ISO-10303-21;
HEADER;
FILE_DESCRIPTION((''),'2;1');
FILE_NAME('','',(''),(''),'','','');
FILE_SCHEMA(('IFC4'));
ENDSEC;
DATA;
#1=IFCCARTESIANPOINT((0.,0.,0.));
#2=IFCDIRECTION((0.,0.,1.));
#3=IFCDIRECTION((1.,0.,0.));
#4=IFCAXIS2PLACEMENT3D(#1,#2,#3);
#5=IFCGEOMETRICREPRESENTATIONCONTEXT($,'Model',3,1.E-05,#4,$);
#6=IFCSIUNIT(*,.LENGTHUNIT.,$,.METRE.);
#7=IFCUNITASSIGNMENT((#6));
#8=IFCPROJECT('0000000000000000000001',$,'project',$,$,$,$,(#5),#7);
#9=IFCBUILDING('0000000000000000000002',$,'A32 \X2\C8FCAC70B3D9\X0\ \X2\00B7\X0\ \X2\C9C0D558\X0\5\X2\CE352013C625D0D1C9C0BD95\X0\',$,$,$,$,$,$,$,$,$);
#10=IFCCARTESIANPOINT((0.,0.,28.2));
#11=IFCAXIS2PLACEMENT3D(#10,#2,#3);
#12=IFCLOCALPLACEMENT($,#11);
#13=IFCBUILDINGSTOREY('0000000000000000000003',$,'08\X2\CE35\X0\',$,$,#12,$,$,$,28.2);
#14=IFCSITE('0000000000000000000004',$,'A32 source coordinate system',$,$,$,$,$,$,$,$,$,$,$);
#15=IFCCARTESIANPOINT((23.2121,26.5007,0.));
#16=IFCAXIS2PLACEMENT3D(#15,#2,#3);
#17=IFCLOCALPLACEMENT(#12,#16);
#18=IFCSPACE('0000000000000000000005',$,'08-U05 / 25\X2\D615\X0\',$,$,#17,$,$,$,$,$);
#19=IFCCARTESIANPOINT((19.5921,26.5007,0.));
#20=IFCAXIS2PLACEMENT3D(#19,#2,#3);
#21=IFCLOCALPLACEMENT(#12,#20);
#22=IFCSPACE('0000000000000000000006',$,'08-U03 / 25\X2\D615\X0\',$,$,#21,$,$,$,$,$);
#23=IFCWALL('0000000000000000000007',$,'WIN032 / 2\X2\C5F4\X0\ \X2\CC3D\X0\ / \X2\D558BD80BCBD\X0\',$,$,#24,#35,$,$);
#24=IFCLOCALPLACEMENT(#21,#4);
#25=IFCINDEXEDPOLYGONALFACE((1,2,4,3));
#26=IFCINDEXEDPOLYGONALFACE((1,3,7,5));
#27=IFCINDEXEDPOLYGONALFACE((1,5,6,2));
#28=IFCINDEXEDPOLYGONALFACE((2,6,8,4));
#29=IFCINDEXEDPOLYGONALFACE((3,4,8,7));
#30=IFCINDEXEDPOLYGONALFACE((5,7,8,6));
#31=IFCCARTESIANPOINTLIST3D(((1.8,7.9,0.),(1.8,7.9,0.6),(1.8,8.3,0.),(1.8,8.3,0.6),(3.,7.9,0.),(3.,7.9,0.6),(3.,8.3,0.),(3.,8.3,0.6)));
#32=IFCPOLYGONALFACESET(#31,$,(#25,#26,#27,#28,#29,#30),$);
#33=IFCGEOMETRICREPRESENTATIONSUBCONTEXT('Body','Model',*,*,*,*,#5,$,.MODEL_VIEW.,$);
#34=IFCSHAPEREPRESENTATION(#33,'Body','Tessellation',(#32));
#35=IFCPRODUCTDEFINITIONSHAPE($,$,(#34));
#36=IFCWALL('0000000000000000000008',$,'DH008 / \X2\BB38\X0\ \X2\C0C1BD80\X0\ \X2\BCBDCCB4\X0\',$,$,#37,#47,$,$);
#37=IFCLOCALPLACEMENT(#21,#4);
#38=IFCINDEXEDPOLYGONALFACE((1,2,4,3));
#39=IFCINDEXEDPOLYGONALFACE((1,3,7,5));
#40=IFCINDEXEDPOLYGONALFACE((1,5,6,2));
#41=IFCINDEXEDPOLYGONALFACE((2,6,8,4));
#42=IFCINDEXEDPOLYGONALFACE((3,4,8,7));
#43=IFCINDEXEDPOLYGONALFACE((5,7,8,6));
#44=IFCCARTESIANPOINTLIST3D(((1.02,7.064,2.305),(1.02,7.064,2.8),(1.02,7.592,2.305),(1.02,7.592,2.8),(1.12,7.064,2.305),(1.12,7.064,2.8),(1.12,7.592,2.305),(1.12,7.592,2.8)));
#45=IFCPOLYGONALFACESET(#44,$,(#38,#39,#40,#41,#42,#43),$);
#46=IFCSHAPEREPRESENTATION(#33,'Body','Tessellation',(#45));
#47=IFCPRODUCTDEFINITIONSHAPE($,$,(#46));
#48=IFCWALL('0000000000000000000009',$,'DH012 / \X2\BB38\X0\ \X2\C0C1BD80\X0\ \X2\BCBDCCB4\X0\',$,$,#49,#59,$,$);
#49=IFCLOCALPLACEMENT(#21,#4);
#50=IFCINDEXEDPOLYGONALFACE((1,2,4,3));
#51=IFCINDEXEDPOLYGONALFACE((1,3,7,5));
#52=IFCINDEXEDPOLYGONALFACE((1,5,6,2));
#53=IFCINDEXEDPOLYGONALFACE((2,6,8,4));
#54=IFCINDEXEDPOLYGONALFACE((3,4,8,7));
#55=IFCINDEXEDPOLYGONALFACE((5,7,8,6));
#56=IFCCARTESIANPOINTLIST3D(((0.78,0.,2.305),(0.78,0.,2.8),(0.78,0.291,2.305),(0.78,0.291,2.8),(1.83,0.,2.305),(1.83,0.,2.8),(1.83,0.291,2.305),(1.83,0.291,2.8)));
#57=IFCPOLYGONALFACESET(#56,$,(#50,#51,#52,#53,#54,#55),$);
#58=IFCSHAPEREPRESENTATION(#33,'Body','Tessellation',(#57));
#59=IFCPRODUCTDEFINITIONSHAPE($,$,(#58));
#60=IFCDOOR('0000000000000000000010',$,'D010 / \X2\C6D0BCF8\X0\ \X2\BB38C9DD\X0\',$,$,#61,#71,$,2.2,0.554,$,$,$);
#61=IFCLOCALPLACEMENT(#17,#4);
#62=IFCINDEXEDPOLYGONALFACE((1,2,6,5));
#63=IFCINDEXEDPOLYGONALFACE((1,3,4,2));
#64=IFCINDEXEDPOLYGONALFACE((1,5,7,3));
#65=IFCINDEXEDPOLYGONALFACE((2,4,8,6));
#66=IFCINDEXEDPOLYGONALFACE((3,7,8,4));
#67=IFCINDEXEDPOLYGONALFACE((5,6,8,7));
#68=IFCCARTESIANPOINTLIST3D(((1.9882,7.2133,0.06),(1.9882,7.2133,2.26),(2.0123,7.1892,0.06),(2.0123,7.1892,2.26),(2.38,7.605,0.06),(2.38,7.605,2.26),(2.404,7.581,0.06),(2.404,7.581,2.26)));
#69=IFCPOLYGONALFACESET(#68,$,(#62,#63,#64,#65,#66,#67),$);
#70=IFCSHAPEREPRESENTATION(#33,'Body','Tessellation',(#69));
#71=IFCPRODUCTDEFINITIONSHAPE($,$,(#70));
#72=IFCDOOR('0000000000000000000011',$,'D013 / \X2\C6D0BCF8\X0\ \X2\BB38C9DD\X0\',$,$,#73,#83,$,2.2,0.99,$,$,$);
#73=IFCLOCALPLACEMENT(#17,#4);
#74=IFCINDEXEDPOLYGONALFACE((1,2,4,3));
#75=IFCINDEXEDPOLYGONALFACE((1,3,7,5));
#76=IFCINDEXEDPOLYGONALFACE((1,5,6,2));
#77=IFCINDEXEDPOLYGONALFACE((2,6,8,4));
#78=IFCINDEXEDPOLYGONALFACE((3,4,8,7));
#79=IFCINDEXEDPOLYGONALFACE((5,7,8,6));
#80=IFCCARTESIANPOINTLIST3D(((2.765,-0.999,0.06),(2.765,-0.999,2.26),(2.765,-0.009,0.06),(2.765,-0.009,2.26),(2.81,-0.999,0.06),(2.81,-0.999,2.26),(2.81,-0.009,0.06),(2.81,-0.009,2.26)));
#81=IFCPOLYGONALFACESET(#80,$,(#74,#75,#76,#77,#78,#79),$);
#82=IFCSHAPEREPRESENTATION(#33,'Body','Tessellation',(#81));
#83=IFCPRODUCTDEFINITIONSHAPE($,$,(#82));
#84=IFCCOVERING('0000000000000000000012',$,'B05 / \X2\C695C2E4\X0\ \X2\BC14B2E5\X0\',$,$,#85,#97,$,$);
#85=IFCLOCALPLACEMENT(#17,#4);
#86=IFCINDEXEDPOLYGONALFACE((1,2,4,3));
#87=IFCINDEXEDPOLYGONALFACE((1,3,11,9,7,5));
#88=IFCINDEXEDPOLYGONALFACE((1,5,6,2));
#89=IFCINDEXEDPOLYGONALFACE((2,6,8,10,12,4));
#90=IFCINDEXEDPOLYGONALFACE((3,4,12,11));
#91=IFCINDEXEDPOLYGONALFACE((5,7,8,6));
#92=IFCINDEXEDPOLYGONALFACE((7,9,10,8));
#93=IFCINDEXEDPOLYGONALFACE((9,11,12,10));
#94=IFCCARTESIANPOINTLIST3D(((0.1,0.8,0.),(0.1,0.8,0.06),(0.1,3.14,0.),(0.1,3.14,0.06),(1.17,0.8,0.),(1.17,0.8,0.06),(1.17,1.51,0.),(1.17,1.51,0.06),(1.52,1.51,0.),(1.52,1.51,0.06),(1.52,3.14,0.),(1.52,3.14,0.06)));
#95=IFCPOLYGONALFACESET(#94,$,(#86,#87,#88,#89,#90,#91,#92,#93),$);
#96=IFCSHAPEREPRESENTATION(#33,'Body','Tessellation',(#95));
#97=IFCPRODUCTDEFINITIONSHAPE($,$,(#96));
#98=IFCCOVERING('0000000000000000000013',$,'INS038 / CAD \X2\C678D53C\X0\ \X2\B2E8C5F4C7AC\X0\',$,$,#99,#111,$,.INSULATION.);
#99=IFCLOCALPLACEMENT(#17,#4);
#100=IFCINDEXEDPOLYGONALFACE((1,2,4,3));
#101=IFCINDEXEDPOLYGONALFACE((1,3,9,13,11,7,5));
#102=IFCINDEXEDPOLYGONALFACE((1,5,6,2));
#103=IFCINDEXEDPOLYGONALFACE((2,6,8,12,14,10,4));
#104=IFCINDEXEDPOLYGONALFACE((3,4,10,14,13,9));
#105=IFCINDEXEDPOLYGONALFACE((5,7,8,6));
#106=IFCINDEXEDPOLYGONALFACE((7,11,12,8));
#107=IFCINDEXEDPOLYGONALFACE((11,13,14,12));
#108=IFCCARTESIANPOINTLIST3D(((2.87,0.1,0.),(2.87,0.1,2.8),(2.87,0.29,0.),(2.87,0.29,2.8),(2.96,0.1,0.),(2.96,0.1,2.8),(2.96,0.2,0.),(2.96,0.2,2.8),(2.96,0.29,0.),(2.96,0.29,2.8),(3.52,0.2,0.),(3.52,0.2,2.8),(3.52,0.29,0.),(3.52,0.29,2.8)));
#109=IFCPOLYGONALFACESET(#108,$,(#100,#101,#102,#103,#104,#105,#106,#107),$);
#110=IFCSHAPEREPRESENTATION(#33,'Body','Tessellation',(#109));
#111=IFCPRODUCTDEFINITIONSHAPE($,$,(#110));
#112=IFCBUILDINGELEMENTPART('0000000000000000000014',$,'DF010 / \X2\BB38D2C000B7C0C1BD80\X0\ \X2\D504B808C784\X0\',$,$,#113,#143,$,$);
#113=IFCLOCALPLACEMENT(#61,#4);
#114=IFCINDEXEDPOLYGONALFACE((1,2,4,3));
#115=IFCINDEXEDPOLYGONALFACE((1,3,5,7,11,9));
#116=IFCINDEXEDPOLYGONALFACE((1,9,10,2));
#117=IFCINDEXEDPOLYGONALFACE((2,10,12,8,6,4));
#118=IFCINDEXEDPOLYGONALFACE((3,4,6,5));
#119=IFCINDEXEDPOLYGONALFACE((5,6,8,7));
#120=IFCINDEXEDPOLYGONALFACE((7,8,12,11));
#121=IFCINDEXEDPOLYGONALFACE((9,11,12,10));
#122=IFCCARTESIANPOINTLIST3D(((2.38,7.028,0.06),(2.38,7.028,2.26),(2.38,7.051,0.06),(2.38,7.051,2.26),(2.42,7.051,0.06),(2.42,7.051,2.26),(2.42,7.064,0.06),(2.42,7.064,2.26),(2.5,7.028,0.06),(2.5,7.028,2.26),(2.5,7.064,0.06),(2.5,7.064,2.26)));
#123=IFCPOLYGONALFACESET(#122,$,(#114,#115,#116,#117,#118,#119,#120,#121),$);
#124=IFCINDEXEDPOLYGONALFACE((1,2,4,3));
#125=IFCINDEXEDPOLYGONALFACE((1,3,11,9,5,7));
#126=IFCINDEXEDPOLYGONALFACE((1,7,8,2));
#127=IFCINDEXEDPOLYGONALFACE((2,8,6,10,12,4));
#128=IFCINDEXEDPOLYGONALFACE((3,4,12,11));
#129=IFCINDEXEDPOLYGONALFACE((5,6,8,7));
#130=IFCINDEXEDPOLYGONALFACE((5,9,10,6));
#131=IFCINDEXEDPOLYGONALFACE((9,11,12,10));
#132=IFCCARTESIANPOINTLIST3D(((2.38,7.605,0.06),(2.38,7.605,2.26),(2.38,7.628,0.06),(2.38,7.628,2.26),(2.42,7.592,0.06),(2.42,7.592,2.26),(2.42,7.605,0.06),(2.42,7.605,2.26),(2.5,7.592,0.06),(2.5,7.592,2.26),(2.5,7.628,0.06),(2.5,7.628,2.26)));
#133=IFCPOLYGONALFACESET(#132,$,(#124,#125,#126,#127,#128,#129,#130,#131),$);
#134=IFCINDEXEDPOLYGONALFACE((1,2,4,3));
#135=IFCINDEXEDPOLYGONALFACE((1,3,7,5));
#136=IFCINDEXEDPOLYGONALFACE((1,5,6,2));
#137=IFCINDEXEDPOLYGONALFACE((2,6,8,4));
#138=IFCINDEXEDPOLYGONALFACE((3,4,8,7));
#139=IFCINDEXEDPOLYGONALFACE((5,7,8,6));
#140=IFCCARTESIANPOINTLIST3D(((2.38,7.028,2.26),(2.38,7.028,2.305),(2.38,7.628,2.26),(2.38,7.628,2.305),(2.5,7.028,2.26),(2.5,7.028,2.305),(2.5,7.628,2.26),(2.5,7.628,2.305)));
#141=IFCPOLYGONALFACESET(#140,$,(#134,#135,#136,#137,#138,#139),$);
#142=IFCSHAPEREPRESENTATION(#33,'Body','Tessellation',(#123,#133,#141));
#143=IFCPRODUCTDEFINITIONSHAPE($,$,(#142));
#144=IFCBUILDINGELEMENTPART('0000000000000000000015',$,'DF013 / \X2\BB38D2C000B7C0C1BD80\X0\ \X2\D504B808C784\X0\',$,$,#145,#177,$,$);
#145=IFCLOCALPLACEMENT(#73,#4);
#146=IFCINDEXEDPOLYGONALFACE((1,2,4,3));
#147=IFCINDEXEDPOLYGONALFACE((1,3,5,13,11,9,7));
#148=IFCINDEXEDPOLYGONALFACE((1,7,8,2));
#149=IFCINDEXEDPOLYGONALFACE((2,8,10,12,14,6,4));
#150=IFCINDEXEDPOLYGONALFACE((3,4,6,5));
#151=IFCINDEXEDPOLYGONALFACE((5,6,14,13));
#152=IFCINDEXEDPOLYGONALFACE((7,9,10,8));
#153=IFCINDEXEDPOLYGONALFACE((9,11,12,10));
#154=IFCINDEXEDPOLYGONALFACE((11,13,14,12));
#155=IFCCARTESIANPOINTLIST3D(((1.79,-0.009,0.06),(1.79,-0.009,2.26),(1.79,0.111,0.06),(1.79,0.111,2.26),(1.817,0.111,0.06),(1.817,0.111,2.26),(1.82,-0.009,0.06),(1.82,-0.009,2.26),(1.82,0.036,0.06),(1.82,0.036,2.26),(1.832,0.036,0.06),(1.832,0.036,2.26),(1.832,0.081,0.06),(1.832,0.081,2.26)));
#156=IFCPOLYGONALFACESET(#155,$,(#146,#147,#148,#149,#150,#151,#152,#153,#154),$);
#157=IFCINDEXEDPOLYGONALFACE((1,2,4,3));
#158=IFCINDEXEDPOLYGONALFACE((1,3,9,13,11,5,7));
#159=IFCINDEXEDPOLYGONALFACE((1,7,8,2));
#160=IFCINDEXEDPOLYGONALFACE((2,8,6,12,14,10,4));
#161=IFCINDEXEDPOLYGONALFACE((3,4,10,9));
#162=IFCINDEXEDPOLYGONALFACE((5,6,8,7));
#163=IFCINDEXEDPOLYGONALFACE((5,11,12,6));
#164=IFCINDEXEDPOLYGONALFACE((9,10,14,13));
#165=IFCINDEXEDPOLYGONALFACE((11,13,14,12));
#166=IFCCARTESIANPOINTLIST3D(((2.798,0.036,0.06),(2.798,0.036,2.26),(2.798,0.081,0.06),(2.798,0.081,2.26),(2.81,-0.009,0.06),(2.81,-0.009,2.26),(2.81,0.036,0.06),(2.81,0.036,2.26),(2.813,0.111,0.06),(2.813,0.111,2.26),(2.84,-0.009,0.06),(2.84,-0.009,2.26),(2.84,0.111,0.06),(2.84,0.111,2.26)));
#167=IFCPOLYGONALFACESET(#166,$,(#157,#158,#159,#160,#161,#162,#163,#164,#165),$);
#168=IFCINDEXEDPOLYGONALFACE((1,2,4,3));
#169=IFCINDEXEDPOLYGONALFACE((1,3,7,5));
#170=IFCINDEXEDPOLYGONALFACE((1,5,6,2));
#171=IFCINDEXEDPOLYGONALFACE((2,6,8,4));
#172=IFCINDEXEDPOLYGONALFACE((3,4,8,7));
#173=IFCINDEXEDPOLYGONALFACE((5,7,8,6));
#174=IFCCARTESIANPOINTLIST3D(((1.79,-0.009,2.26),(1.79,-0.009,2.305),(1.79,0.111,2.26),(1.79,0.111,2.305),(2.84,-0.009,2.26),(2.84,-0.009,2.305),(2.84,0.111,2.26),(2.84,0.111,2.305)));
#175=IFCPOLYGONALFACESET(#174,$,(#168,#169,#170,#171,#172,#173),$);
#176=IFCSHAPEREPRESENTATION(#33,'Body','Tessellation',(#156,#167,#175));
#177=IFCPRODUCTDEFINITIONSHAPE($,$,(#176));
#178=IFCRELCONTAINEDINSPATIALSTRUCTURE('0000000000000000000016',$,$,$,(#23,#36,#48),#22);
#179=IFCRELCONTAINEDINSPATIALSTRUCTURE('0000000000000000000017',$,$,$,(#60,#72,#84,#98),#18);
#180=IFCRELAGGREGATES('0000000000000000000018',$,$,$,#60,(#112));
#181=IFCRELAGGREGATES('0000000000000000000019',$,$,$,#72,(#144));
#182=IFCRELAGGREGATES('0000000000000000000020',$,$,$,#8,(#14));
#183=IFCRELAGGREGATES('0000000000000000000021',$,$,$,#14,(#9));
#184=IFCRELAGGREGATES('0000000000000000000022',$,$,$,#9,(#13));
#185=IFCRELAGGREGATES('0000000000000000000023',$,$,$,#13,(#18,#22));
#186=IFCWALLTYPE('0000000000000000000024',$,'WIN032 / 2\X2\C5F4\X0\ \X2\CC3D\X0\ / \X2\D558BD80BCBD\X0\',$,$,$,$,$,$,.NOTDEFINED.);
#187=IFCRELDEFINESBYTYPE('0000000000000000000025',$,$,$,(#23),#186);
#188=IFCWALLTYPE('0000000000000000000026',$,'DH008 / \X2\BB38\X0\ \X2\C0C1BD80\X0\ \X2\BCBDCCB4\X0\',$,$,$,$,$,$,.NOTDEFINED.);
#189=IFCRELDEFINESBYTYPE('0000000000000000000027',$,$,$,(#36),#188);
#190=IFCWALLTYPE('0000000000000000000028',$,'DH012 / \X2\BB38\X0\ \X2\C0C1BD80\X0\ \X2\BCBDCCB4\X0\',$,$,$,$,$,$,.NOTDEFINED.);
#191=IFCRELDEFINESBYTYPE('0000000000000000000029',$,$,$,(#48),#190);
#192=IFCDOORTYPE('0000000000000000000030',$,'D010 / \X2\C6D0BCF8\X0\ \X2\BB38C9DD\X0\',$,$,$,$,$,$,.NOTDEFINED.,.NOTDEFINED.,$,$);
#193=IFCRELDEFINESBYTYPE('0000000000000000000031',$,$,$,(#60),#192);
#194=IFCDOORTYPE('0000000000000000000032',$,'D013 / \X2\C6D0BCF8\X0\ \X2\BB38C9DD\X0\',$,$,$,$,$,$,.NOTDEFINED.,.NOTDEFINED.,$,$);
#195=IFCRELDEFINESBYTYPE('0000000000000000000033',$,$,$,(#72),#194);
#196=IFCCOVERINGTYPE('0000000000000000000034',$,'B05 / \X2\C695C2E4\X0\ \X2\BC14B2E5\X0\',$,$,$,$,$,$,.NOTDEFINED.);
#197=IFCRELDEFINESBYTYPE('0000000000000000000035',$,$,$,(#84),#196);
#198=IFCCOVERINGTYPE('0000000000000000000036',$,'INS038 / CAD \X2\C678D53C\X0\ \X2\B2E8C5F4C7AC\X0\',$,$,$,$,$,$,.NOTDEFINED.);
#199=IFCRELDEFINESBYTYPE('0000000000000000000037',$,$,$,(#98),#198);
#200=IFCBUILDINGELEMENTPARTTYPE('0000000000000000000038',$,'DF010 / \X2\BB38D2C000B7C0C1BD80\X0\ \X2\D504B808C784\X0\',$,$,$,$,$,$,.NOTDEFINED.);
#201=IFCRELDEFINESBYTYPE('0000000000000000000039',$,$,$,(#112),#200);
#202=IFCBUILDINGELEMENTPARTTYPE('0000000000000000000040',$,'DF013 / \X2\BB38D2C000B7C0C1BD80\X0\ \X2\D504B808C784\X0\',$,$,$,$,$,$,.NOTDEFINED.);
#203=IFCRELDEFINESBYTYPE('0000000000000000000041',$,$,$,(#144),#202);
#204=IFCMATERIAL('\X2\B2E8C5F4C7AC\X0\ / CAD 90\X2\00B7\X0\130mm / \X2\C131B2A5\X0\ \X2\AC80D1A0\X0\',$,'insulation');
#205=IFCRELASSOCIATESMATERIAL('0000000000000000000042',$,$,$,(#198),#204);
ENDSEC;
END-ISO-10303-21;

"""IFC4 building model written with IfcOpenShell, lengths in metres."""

from ifc_helpers import new_model, si_unit, frame, origin, origin_with_axes, place, context, subcontext, project, spatial, polyline, outline, extrude, source, transform, mapped, material, type_object, type_shapes, element, aggregate, save


model = new_model("IFC4")

# Units and contexts
model_context = context("Model", 3, precision=1e-05, world=origin_with_axes())
body_context = subcontext(model_context, "Body", "Model", "MODEL_VIEW")
ifc_project = project(units=[si_unit("LENGTHUNIT", "METRE")], contexts=[model_context])

# Site, building, storey, space
storey_placement = place(None, frame((0.0, 0.0, 28.2), z_axis=(0.0, 0.0, 1.0), x_axis=(1.0, 0.0, 0.0)))
space_1_placement = place(storey_placement, frame((23.2121, 26.5007, 0.0), z_axis=(0.0, 0.0, 1.0), x_axis=(1.0, 0.0, 0.0)))
site = spatial("IfcSite", under=ifc_project, Name="A32 source coordinate system")
building = spatial("IfcBuilding", under=site, Name="A32 주거동 · 지하5층–옥탑지붕")
storey = spatial("IfcBuildingStorey", under=building, at=storey_placement, Name="08층", Elevation=28.2)
space_1 = spatial("IfcSpace", under=storey, at=space_1_placement, Name="08-U05 / 25형")

# Shared definitions
space_2_placement = place(storey_placement, frame((19.5921, 26.5007, 0.0), z_axis=(0.0, 0.0, 1.0), x_axis=(1.0, 0.0, 0.0)))
space_2 = spatial("IfcSpace", under=storey, at=space_2_placement, Name="08-U03 / 25형")

# Walls
wall_type_1 = type_object("IfcWallType", Name="WIN032 / 2열 창 / 하부벽", PredefinedType="NOTDEFINED")
shared_shape_1 = source(origin(), body_context, "Body", "SweptSolid", [
    extrude(outline(polyline([(3.0, 7.9), (1.8, 7.9), (1.8, 8.3), (3.0, 8.3), (3.0, 7.9)])), origin(), (0.0, 0.0, 1.0), 0.6),
])
type_shapes(wall_type_1, [shared_shape_1])
wall_1_placement = place(space_2_placement, origin_with_axes())
element("IfcWall", 1, at=wall_1_placement, inside=space_2, type_object=wall_type_1, Name="WIN032 / 2열 창 / 하부벽", context=body_context, shape_type="MappedRepresentation", body=[
    mapped(shared_shape_1, transform((0.0, 0.0, 0.0), scale=1.0)),
])
wall_type_2 = type_object("IfcWallType", Name="DH008 / 문 상부 벽체", PredefinedType="NOTDEFINED")
shared_shape_2 = source(origin(), body_context, "Body", "SweptSolid", [
    extrude(outline(polyline([(1.12, 7.064), (1.02, 7.064), (1.02, 7.592), (1.12, 7.592), (1.12, 7.064)])), frame((0.0, 0.0, 2.305)), (0.0, 0.0, 1.0), 0.495),
])
type_shapes(wall_type_2, [shared_shape_2])
wall_2_placement = place(space_2_placement, origin_with_axes())
element("IfcWall", 2, at=wall_2_placement, inside=space_2, type_object=wall_type_2, Name="DH008 / 문 상부 벽체", context=body_context, shape_type="MappedRepresentation", body=[
    mapped(shared_shape_2, transform((0.0, 0.0, 0.0), scale=1.0)),
])
wall_type_3 = type_object("IfcWallType", Name="DH012 / 문 상부 벽체", PredefinedType="NOTDEFINED")
shared_shape_3 = source(origin(), body_context, "Body", "SweptSolid", [
    extrude(outline(polyline([(0.78, 0.0), (0.78, 0.291), (1.83, 0.291), (1.83, 0.0), (0.78, 0.0)])), frame((0.0, 0.0, 2.305)), (0.0, 0.0, 1.0), 0.495),
])
type_shapes(wall_type_3, [shared_shape_3])
wall_3_placement = place(space_2_placement, origin_with_axes())
element("IfcWall", 3, at=wall_3_placement, inside=space_2, type_object=wall_type_3, Name="DH012 / 문 상부 벽체", context=body_context, shape_type="MappedRepresentation", body=[
    mapped(shared_shape_3, transform((0.0, 0.0, 0.0), scale=1.0)),
])

# Doors
door_type_1 = type_object("IfcDoorType", Name="D010 / 원본 문짝", OperationType="NOTDEFINED", PredefinedType="NOTDEFINED")
shared_shape_4 = source(origin(), body_context, "Body", "SweptSolid", [
    extrude(outline(polyline([(2.0123, 7.1892), (1.9882, 7.2133), (2.38, 7.605), (2.404, 7.581), (2.0123, 7.1892)])), frame((0.0, 0.0, 0.06)), (0.0, 0.0, 1.0), 2.2),
])
type_shapes(door_type_1, [shared_shape_4])
door_1_placement = place(space_1_placement, origin_with_axes())
door_1 = element("IfcDoor", 4, at=door_1_placement, inside=space_1, type_object=door_type_1, Name="D010 / 원본 문짝", OverallHeight=2.2, OverallWidth=0.554, context=body_context, shape_type="MappedRepresentation", body=[
    mapped(shared_shape_4, transform((0.0, 0.0, 0.0), scale=1.0)),
])
door_type_2 = type_object("IfcDoorType", Name="D013 / 원본 문짝", OperationType="NOTDEFINED", PredefinedType="NOTDEFINED")
shared_shape_5 = source(origin(), body_context, "Body", "SweptSolid", [
    extrude(outline(polyline([(2.81, -0.009), (2.81, -0.999), (2.765, -0.999), (2.765, -0.009), (2.81, -0.009)])), frame((0.0, 0.0, 0.06)), (0.0, 0.0, 1.0), 2.2),
])
type_shapes(door_type_2, [shared_shape_5])
door_2_placement = place(space_1_placement, origin_with_axes())
door_2 = element("IfcDoor", 5, at=door_2_placement, inside=space_1, type_object=door_type_2, Name="D013 / 원본 문짝", OverallHeight=2.2, OverallWidth=0.99, context=body_context, shape_type="MappedRepresentation", body=[
    mapped(shared_shape_5, transform((0.0, 0.0, 0.0), scale=1.0)),
])

# Coverings
covering_type_1 = type_object("IfcCoveringType", Name="B05 / 욕실 바닥", PredefinedType="NOTDEFINED")
shared_shape_6 = source(origin(), body_context, "Body", "SweptSolid", [
    extrude(outline(polyline([(0.1, 3.14), (1.52, 3.14), (1.52, 1.51), (1.17, 1.51), (1.17, 0.8), (0.1, 0.8), (0.1, 3.14)])), origin(), (0.0, 0.0, 1.0), 0.06),
])
type_shapes(covering_type_1, [shared_shape_6])
covering_1_placement = place(space_1_placement, origin_with_axes())
element("IfcCovering", 6, at=covering_1_placement, inside=space_1, type_object=covering_type_1, Name="B05 / 욕실 바닥", context=body_context, shape_type="MappedRepresentation", body=[
    mapped(shared_shape_6, transform((0.0, 0.0, 0.0), scale=1.0)),
])
ifc_material = material(Name="단열재 / CAD 90·130mm / 성능 검토", Category="insulation")
covering_type_2 = type_object("IfcCoveringType", Name="INS038 / CAD 외피 단열재", PredefinedType="NOTDEFINED", material=ifc_material)
shared_shape_7 = source(origin(), body_context, "Body", "SweptSolid", [
    extrude(outline(polyline([(2.96, 0.2), (2.96, 0.1), (2.87, 0.1), (2.87, 0.29), (2.96, 0.29), (3.52, 0.29), (3.52, 0.2), (2.96, 0.2)])), origin(), (0.0, 0.0, 1.0), 2.8),
])
type_shapes(covering_type_2, [shared_shape_7])
covering_2_placement = place(space_1_placement, origin_with_axes())
element("IfcCovering", 7, at=covering_2_placement, inside=space_1, type_object=covering_type_2, Name="INS038 / CAD 외피 단열재", PredefinedType="INSULATION", context=body_context, shape_type="MappedRepresentation", body=[
    mapped(shared_shape_7, transform((0.0, 0.0, 0.0), scale=1.0)),
])

# Building element parts
building_element_part_type_1 = type_object("IfcBuildingElementPartType", Name="DF010 / 문틀·상부 프레임", PredefinedType="NOTDEFINED")
shared_shape_8 = source(origin(), body_context, "Body", "SweptSolid", [
    extrude(outline(polyline([(2.38, 7.028), (2.38, 7.051), (2.42, 7.051), (2.42, 7.064), (2.5, 7.064), (2.5, 7.028), (2.38, 7.028)])), frame((0.0, 0.0, 0.06)), (0.0, 0.0, 1.0), 2.2),
    extrude(outline(polyline([(2.5, 7.592), (2.42, 7.592), (2.42, 7.605), (2.38, 7.605), (2.38, 7.628), (2.5, 7.628), (2.5, 7.592)])), frame((0.0, 0.0, 0.06)), (0.0, 0.0, 1.0), 2.2),
    extrude(outline(polyline([(2.38, 7.028), (2.38, 7.628), (2.5, 7.628), (2.5, 7.028), (2.38, 7.028)])), frame((0.0, 0.0, 2.26)), (0.0, 0.0, 1.0), 0.045),
])
type_shapes(building_element_part_type_1, [shared_shape_8])
building_element_part_1_placement = place(door_1_placement, origin_with_axes())
building_element_part_1 = element("IfcBuildingElementPart", 8, at=building_element_part_1_placement, type_object=building_element_part_type_1, Name="DF010 / 문틀·상부 프레임", context=body_context, shape_type="MappedRepresentation", body=[
    mapped(shared_shape_8, transform((0.0, 0.0, 0.0), scale=1.0)),
])
aggregate(door_1, [building_element_part_1])
building_element_part_type_2 = type_object("IfcBuildingElementPartType", Name="DF013 / 문틀·상부 프레임", PredefinedType="NOTDEFINED")
shared_shape_9 = source(origin(), body_context, "Body", "SweptSolid", [
    extrude(outline(polyline([(1.79, 0.111), (1.817, 0.111), (1.832, 0.081), (1.832, 0.036), (1.82, 0.036), (1.82, -0.009), (1.79, -0.009), (1.79, 0.111)])), frame((0.0, 0.0, 0.06)), (0.0, 0.0, 1.0), 2.2),
    extrude(outline(polyline([(2.81, -0.009), (2.81, 0.036), (2.798, 0.036), (2.798, 0.081), (2.813, 0.111), (2.84, 0.111), (2.84, -0.009), (2.81, -0.009)])), frame((0.0, 0.0, 0.06)), (0.0, 0.0, 1.0), 2.2),
    extrude(outline(polyline([(1.79, -0.009), (1.79, 0.111), (2.84, 0.111), (2.84, -0.009), (1.79, -0.009)])), frame((0.0, 0.0, 2.26)), (0.0, 0.0, 1.0), 0.045),
])
type_shapes(building_element_part_type_2, [shared_shape_9])
building_element_part_2_placement = place(door_2_placement, origin_with_axes())
building_element_part_2 = element("IfcBuildingElementPart", 9, at=building_element_part_2_placement, type_object=building_element_part_type_2, Name="DF013 / 문틀·상부 프레임", context=body_context, shape_type="MappedRepresentation", body=[
    mapped(shared_shape_9, transform((0.0, 0.0, 0.0), scale=1.0)),
])
aggregate(door_2, [building_element_part_2])

save(model, "model.ifc")
